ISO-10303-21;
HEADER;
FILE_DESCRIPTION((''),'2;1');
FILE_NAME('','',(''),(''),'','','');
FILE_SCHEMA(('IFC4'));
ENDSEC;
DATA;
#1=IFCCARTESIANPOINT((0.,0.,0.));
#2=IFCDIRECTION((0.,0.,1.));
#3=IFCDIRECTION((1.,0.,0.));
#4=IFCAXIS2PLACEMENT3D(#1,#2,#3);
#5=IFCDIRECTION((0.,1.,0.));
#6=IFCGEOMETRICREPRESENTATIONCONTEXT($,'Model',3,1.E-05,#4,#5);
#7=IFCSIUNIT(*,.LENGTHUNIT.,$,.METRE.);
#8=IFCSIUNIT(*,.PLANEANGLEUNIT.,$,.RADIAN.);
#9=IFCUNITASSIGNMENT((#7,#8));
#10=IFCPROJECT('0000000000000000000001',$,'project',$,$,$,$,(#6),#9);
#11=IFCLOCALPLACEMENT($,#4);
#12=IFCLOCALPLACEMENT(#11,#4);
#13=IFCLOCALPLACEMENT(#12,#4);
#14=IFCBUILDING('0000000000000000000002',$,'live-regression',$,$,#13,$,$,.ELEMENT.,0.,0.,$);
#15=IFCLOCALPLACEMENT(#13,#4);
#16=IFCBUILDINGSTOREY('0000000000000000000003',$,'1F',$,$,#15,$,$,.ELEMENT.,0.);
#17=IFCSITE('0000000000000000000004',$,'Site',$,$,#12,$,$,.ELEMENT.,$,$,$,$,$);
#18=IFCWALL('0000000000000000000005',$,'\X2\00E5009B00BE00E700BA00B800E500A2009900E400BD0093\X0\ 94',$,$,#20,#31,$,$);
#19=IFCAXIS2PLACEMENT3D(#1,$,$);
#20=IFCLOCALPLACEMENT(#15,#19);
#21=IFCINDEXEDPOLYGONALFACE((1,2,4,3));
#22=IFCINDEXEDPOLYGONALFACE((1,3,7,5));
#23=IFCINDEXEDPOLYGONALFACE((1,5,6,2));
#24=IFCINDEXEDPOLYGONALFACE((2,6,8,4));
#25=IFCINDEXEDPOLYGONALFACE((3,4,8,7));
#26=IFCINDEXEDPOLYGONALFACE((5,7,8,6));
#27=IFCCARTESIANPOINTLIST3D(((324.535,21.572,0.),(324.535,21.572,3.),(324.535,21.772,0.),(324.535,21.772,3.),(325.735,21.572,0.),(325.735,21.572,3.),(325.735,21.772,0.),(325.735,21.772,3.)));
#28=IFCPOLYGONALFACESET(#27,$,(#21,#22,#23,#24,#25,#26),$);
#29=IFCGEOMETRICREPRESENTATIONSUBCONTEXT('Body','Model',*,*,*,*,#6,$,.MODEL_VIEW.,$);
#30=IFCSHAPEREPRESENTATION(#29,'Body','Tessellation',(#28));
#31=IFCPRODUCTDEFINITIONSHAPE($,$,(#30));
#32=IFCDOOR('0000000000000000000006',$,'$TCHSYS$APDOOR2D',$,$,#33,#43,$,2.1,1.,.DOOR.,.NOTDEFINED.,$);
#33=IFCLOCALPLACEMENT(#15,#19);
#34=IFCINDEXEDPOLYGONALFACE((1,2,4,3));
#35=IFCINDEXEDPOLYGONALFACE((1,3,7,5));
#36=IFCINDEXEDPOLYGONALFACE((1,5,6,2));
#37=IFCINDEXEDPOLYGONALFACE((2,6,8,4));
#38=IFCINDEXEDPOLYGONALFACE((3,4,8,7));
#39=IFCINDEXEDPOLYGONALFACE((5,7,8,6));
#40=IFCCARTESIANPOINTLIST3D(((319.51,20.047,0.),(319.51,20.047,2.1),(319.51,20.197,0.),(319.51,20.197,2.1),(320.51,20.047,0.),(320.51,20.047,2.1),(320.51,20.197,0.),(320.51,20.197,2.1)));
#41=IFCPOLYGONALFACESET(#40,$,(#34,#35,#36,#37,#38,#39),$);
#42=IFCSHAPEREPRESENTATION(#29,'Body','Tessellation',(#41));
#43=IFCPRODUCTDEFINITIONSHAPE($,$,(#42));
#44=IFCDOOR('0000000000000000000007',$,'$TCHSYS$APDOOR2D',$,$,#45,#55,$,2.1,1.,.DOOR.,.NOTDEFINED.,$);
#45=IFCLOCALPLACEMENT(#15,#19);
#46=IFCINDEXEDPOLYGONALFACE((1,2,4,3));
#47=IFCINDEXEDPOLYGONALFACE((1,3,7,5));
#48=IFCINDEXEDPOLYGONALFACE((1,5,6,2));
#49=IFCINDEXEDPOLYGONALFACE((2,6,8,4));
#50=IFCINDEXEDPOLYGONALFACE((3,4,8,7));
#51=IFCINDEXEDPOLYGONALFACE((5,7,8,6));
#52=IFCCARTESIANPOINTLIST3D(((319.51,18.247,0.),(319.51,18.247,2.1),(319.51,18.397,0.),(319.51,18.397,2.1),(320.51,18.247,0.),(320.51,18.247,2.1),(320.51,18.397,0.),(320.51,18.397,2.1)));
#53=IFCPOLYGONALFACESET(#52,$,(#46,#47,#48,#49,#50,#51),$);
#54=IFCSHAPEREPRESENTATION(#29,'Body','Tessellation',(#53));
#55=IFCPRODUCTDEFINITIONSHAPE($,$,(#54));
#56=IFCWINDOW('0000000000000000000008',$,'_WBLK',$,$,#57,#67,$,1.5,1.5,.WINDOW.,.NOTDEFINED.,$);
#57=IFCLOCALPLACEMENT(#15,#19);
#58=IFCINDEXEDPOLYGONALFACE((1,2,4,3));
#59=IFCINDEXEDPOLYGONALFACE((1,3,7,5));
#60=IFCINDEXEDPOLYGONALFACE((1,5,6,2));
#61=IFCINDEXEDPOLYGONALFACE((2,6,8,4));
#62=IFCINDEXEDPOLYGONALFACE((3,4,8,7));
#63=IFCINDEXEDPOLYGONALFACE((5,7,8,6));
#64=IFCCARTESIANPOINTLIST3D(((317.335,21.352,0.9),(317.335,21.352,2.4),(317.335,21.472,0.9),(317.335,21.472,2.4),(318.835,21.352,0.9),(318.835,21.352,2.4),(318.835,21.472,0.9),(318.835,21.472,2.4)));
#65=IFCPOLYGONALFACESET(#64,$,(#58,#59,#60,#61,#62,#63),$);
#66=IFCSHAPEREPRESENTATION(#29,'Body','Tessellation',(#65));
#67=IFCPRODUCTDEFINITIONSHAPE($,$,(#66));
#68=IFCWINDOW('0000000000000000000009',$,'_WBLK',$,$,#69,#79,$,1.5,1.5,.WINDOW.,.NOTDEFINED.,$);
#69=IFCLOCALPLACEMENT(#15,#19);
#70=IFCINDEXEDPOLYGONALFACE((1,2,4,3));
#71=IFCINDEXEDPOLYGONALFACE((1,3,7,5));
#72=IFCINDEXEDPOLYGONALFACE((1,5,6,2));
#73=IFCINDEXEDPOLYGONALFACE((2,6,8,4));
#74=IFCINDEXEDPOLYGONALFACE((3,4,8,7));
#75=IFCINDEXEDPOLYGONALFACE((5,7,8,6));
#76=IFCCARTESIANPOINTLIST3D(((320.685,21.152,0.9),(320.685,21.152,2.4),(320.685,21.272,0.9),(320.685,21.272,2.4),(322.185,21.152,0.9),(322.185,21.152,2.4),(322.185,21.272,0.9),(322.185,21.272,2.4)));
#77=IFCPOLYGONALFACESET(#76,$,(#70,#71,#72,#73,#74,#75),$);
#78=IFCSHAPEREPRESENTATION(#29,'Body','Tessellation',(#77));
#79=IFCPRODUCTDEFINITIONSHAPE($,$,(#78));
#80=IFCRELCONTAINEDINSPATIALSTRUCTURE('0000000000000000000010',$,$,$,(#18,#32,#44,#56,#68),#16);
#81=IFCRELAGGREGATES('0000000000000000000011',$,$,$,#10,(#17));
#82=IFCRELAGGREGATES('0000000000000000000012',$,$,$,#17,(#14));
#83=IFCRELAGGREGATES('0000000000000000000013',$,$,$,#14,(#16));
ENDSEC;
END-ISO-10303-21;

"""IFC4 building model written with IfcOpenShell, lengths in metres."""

from ifc_helpers import new_model, si_unit, direction, frame, frame_2d, origin_with_axes, place, context, subcontext, project, spatial, rectangle, extrude, element, save


model = new_model("IFC4")

# Units and contexts
model_context = context("Model", 3, precision=1e-05, world=origin_with_axes(), true_north=direction((0.0, 1.0, 0.0)))
body_context = subcontext(model_context, "Body", "Model", "MODEL_VIEW")
ifc_project = project(units=[si_unit("LENGTHUNIT", "METRE"), si_unit("PLANEANGLEUNIT", "RADIAN")], contexts=[model_context])

# Site, building, storey
placement = place(None, origin_with_axes())
site_placement = place(placement, origin_with_axes())
site = spatial("IfcSite", under=ifc_project, at=site_placement, Name="Site", CompositionType="ELEMENT")
building_placement = place(site_placement, origin_with_axes())
building = spatial("IfcBuilding", under=site, at=building_placement, Name="live-regression", CompositionType="ELEMENT", ElevationOfRefHeight=0.0, ElevationOfTerrain=0.0)
storey_placement = place(building_placement, origin_with_axes())
storey = spatial("IfcBuildingStorey", under=building, at=storey_placement, Name="1F", CompositionType="ELEMENT", Elevation=0.0)

# Wall
wall_1_placement = place(storey_placement, frame((325.135, 21.672, 0.0), z_axis=(0.0, 0.0, 1.0), x_axis=(1.0, 0.0, 0.0)))
element("IfcWall", 1, at=wall_1_placement, inside=storey, Name="å\u009b¾çº¸å¢\u0099ä½\u0093 94", context=body_context, shape_type="SweptSolid", body=[
    extrude(rectangle(XDim=1.2, YDim=0.2, at=frame_2d((0.0, 0.0), x_axis=(1.0, 0.0, 0.0))), frame((0.0, 0.0, 0.0), z_axis=(0.0, 0.0, 1.0)), (0.0, 0.0, 1.0), 3.0),
])

# Doors
for number, where, z_axis, x_axis, name in (
    (2, (320.01, 20.122, 0.0), (0.0, 0.0, 1.0), (1.0, 0.0, 0.0), "$TCHSYS$APDOOR2D"),
    (3, (320.01, 18.322, 0.0), (0.0, 0.0, 1.0), (1.0, 0.0, 0.0), "$TCHSYS$APDOOR2D"),
):
    element("IfcDoor", number, at=place(storey_placement, frame(where, z_axis=z_axis, x_axis=x_axis)), inside=storey, Name=name, OperationType="NOTDEFINED", OverallHeight=2.1, OverallWidth=1.0, PredefinedType="DOOR", context=body_context, shape_type="SweptSolid", body=[
        extrude(rectangle(XDim=1.0, YDim=0.15, at=frame_2d((0.0, 0.0), x_axis=(1.0, 0.0, 0.0))), frame((0.0, 0.0, 0.0), z_axis=(0.0, 0.0, 1.0)), (0.0, 0.0, 1.0), 2.1),
    ])

# Windows
for number, where, z_axis, x_axis, name in (
    (4, (318.085, 21.412, 0.9), (0.0, 0.0, 1.0), (1.0, 0.0, 0.0), "_WBLK"),
    (5, (321.435, 21.212, 0.9), (0.0, 0.0, 1.0), (1.0, 0.0, 0.0), "_WBLK"),
):
    element("IfcWindow", number, at=place(storey_placement, frame(where, z_axis=z_axis, x_axis=x_axis)), inside=storey, Name=name, OverallHeight=1.5, OverallWidth=1.5, PartitioningType="NOTDEFINED", PredefinedType="WINDOW", context=body_context, shape_type="SweptSolid", body=[
        extrude(rectangle(XDim=1.5, YDim=0.12, at=frame_2d((0.0, 0.0), x_axis=(1.0, 0.0, 0.0))), frame((0.0, 0.0, 0.0), z_axis=(0.0, 0.0, 1.0)), (0.0, 0.0, 1.0), 1.5),
    ])

save(model, "model.ifc")
